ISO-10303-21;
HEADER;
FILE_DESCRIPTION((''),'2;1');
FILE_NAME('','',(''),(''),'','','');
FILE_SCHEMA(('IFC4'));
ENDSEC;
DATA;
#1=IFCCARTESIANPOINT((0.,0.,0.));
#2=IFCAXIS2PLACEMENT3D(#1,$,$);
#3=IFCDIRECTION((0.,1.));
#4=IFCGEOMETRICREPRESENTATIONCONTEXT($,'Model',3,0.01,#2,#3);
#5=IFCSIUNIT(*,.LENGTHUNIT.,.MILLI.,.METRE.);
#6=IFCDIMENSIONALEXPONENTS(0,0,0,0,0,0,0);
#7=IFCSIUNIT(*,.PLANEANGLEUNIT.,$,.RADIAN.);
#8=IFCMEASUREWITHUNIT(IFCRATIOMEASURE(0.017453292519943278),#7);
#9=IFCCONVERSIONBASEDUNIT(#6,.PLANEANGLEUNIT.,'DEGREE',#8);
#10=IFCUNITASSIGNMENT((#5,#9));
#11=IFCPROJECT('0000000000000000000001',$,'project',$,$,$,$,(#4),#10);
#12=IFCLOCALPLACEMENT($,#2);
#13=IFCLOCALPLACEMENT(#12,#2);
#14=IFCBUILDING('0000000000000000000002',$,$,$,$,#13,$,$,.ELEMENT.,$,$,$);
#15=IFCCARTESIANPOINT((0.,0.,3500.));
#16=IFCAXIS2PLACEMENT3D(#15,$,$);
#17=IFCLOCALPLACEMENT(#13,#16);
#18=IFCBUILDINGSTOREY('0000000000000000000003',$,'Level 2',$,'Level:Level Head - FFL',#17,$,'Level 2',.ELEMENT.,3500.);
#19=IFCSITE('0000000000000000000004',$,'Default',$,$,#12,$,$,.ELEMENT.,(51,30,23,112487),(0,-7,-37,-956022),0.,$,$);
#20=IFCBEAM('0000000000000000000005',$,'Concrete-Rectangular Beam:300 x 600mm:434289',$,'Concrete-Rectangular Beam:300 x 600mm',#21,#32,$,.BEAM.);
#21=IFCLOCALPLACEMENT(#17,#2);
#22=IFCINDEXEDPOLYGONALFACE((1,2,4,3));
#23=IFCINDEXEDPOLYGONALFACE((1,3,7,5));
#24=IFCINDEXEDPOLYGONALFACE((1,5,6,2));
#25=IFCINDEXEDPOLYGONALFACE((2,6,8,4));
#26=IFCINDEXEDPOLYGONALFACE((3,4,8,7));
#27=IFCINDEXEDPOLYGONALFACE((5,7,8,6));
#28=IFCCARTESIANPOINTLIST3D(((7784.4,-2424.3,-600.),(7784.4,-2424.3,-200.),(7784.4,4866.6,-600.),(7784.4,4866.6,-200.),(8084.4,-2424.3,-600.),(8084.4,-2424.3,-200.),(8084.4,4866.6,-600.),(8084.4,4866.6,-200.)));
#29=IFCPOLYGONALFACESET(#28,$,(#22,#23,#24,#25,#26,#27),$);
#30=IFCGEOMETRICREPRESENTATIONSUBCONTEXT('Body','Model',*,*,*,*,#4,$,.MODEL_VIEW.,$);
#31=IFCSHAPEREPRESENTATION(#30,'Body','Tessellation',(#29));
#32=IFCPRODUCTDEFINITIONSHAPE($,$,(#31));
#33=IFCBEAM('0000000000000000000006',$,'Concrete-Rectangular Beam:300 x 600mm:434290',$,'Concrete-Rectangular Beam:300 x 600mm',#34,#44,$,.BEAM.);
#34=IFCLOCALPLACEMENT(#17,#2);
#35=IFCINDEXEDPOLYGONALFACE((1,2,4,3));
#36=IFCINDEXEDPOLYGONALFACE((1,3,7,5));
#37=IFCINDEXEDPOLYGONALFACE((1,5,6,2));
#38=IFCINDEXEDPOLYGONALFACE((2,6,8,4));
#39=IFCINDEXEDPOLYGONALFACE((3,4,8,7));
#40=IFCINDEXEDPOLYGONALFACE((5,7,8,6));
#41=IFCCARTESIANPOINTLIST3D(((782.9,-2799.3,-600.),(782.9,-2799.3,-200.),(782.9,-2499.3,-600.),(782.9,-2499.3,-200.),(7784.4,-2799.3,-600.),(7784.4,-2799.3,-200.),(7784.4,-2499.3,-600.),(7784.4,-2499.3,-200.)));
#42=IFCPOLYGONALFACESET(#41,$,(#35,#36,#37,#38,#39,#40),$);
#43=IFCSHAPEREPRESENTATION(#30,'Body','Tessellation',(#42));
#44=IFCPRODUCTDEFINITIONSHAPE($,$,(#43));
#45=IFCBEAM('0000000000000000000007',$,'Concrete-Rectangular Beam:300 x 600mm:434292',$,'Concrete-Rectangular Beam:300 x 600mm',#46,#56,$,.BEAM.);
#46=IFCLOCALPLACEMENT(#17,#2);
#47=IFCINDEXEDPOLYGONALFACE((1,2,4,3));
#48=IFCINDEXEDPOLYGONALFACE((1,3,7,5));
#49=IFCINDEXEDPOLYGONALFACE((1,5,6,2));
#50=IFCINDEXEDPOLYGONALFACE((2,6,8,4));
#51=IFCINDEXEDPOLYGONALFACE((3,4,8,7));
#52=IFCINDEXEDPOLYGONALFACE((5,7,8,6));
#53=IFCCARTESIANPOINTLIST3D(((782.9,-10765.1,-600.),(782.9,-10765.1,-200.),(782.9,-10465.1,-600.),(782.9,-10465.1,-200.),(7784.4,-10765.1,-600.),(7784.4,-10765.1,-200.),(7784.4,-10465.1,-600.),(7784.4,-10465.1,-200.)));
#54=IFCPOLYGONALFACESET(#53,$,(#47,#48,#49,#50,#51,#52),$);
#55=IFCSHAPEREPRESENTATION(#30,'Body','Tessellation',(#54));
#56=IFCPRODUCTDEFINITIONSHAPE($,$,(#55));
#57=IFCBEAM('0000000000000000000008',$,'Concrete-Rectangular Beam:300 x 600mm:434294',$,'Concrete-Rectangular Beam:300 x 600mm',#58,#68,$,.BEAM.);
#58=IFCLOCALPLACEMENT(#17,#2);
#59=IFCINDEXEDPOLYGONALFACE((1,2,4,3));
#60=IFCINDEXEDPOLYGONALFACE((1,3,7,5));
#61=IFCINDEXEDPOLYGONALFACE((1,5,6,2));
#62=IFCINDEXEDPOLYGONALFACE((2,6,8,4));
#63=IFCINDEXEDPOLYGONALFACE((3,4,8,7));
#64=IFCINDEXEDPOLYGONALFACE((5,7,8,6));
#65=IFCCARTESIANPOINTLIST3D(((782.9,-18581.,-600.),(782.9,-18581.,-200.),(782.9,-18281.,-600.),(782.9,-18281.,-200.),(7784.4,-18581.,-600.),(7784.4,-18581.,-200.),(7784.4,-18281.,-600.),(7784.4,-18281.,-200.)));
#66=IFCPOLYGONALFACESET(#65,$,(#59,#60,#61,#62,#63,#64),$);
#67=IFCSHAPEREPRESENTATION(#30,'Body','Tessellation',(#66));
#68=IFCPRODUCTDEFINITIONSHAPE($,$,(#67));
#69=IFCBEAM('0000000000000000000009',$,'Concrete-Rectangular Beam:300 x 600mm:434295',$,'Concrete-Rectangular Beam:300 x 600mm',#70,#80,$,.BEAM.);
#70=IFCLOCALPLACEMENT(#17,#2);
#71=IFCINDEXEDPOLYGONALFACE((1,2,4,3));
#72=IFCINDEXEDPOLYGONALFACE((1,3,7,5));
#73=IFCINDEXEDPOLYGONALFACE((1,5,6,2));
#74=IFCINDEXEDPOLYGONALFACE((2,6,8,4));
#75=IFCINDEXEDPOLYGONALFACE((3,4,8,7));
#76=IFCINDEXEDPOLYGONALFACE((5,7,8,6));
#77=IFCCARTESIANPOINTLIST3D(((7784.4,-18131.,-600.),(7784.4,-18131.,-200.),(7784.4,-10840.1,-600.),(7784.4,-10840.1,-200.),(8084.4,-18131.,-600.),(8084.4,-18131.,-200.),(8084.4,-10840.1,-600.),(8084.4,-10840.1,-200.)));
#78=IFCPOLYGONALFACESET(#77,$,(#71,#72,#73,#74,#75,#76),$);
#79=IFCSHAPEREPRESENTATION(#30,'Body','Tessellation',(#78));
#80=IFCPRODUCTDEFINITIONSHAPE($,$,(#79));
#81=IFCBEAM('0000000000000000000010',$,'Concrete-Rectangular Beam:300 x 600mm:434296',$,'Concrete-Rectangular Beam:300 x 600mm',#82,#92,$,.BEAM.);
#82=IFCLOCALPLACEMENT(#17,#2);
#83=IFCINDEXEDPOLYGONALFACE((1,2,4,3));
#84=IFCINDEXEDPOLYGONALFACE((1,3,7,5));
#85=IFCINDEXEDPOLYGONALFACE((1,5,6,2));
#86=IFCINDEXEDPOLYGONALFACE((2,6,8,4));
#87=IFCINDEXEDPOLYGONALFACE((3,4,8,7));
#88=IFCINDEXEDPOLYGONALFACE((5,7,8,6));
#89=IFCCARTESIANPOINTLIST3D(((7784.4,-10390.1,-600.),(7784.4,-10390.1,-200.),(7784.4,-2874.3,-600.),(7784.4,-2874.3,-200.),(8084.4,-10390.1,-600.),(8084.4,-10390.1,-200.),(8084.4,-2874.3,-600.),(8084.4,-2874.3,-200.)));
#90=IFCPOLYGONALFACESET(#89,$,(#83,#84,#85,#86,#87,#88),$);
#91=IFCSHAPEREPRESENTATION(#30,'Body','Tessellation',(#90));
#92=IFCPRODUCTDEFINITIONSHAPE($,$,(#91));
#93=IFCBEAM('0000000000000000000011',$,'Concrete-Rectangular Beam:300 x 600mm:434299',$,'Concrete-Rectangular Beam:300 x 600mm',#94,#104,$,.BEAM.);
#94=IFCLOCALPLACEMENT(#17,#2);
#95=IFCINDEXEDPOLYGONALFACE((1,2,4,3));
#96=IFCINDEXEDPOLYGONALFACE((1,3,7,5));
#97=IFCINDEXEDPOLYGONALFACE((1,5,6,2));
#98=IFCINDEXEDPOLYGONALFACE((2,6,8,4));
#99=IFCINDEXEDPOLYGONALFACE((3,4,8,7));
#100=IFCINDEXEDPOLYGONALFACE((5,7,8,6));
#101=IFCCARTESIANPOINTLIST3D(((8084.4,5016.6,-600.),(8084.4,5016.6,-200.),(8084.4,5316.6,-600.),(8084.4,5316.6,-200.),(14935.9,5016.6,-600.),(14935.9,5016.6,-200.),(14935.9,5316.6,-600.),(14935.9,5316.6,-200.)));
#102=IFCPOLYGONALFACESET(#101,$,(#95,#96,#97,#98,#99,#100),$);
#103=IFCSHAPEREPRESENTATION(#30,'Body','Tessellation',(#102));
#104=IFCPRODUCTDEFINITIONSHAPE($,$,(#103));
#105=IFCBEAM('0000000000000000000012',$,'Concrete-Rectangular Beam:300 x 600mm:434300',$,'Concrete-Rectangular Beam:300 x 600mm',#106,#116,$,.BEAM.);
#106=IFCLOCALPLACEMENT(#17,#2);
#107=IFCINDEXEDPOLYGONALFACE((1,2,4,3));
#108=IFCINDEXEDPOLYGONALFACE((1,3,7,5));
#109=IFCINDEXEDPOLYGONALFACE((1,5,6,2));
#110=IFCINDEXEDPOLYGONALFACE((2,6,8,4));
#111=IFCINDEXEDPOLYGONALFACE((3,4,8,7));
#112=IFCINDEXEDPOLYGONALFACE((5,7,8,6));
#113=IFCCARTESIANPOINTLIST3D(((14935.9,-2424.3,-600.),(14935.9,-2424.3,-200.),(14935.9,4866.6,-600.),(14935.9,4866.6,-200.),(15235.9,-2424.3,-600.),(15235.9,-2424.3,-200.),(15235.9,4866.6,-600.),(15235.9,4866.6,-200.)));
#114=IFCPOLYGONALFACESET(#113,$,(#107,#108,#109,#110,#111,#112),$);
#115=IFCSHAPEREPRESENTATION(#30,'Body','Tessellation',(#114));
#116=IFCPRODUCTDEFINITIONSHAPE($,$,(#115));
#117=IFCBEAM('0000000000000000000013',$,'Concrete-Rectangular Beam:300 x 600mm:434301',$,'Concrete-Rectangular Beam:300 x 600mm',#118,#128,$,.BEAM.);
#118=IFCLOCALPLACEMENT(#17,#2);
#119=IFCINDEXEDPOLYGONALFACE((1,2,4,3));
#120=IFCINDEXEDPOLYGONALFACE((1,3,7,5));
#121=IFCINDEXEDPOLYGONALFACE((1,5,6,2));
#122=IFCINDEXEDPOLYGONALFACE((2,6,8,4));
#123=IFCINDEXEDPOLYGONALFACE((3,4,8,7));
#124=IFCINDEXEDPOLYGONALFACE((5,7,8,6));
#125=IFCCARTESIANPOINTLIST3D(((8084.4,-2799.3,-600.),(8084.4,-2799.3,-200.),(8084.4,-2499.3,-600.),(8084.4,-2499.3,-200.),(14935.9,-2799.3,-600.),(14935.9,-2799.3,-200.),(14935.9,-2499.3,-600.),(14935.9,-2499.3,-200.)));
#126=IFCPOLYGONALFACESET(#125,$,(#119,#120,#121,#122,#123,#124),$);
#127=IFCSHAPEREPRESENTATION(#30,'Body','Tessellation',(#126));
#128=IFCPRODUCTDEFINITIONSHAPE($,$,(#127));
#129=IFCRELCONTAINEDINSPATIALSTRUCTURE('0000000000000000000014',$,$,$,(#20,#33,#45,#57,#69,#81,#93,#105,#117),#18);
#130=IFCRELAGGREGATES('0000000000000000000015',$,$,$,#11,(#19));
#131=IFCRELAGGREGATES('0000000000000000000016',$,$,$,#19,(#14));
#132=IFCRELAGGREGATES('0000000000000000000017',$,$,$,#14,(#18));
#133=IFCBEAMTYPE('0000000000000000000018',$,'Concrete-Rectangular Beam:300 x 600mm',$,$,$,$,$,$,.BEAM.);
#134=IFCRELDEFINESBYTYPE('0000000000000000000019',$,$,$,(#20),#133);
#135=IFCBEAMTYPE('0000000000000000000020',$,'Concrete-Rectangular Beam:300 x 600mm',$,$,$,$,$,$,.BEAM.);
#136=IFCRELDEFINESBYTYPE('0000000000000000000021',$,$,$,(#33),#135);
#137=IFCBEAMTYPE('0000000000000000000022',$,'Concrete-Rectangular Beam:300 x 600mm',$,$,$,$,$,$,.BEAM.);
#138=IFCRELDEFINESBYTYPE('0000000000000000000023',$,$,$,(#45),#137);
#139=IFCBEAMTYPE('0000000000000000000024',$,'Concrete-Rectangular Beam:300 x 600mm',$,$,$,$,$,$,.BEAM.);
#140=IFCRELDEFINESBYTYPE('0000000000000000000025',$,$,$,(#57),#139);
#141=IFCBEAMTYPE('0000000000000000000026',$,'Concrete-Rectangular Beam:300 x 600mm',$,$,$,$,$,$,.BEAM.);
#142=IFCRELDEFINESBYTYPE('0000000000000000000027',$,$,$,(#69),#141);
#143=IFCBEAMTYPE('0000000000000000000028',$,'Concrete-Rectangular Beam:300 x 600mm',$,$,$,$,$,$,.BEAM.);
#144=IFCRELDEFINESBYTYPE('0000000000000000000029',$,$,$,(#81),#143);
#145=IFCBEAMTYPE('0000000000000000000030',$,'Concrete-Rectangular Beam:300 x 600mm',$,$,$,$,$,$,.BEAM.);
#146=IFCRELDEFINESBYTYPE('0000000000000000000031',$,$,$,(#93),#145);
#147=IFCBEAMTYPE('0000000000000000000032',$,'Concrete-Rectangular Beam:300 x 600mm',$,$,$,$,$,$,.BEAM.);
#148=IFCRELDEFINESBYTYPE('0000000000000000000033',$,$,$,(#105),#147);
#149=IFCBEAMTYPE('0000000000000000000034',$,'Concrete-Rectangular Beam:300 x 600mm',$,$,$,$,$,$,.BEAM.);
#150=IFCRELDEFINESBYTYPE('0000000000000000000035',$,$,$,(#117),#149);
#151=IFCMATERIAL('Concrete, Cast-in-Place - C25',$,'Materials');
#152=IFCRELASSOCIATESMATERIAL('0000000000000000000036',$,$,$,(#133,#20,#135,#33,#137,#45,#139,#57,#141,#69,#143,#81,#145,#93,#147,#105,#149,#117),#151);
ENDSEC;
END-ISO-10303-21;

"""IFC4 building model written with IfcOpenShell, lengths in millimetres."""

from ifc_helpers import new_model, entity, si_unit, converted_unit, direction, frame, origin, place, context, subcontext, project, spatial, indexed_curve, outline, extrude, source, transform, mapped, material, type_object, type_shapes, element, save


model = new_model("IFC4")

# Units and contexts
model_context = context("Model", 3, precision=0.01, world=origin(), true_north=direction((0.0, 1.0)))
body_context = subcontext(model_context, "Body", "Model", "MODEL_VIEW")
ifc_project = project(units=[si_unit("LENGTHUNIT", "METRE", prefix="MILLI"), converted_unit("PLANEANGLEUNIT", "DEGREE", entity("IfcRatioMeasure", 0.017453292519943278), si_unit("PLANEANGLEUNIT", "RADIAN"), dimensions=[0, 0, 0, 0, 0, 0, 0])], contexts=[model_context])

# Site, building, storey
site_placement = place(None, origin())
site = spatial("IfcSite", under=ifc_project, at=site_placement, Name="Default", CompositionType="ELEMENT", RefLatitude=(51, 30, 23, 112487), RefLongitude=(0, -7, -37, -956022), RefElevation=0.0)
building_placement = place(site_placement, origin())
building = spatial("IfcBuilding", under=site, at=building_placement, CompositionType="ELEMENT")
storey_placement = place(building_placement, frame((0.0, 0.0, 3500.0)))
storey = spatial("IfcBuildingStorey", under=building, at=storey_placement, Name="Level 2", ObjectType="Level:Level Head - FFL", LongName="Level 2", CompositionType="ELEMENT", Elevation=3500.0)

# Beams
ifc_material = material(Name="Concrete, Cast-in-Place - C25", Category="Materials")
beam_type_1 = type_object("IfcBeamType", Name="Concrete-Rectangular Beam:300 x 600mm", PredefinedType="BEAM", material=ifc_material)
shared_shape_1 = source(origin(), body_context, "Body", "SweptSolid", [
    extrude(outline(indexed_curve([(-150.0, -200.0), (150.0, -200.0), (150.0, 200.0), (-150.0, 200.0), (-150.0, -200.0)], self_intersect=False)), frame((7934.4, 4866.6, 3100.0), z_axis=(0.0, -1.0, 0.0), x_axis=(-1.0, 0.0, 0.0)), (0.0, 0.0, 1.0), 7290.9),
])
type_shapes(beam_type_1, [shared_shape_1])
beam_1_placement = place(storey_placement, frame((0.0, 0.0, -3500.0)))
element("IfcBeam", 1, at=beam_1_placement, inside=storey, type_object=beam_type_1, material=ifc_material, Name="Concrete-Rectangular Beam:300 x 600mm:434289", ObjectType="Concrete-Rectangular Beam:300 x 600mm", PredefinedType="BEAM", context=body_context, shape_type="MappedRepresentation", body=[
    mapped(shared_shape_1, transform((0.0, 0.0, 0.0), scale=1.0)),
])
beam_type_2 = type_object("IfcBeamType", Name="Concrete-Rectangular Beam:300 x 600mm", PredefinedType="BEAM", material=ifc_material)
shared_shape_2 = source(origin(), body_context, "Body", "SweptSolid", [
    extrude(outline(indexed_curve([(-200.0, -150.0), (200.0, -150.0), (200.0, 150.0), (-200.0, 150.0), (-200.0, -150.0)], self_intersect=False)), frame((7784.4, -2649.3, 3100.0), z_axis=(-1.0, 0.0, 0.0), x_axis=(0.0, 0.0, -1.0)), (0.0, 0.0, 1.0), 7001.5),
])
type_shapes(beam_type_2, [shared_shape_2])
beam_2_placement = place(storey_placement, frame((0.0, 0.0, -3500.0)))
element("IfcBeam", 2, at=beam_2_placement, inside=storey, type_object=beam_type_2, material=ifc_material, Name="Concrete-Rectangular Beam:300 x 600mm:434290", ObjectType="Concrete-Rectangular Beam:300 x 600mm", PredefinedType="BEAM", context=body_context, shape_type="MappedRepresentation", body=[
    mapped(shared_shape_2, transform((0.0, 0.0, 0.0), scale=1.0)),
])
beam_type_3 = type_object("IfcBeamType", Name="Concrete-Rectangular Beam:300 x 600mm", PredefinedType="BEAM", material=ifc_material)
shared_shape_3 = source(origin(), body_context, "Body", "SweptSolid", [
    extrude(outline(indexed_curve([(-200.0, -150.0), (200.0, -150.0), (200.0, 150.0), (-200.0, 150.0), (-200.0, -150.0)], self_intersect=False)), frame((7784.4, -10615.1, 3100.0), z_axis=(-1.0, 0.0, 0.0), x_axis=(0.0, 0.0, -1.0)), (0.0, 0.0, 1.0), 7001.5),
])
type_shapes(beam_type_3, [shared_shape_3])
beam_3_placement = place(storey_placement, frame((0.0, 0.0, -3500.0)))
element("IfcBeam", 3, at=beam_3_placement, inside=storey, type_object=beam_type_3, material=ifc_material, Name="Concrete-Rectangular Beam:300 x 600mm:434292", ObjectType="Concrete-Rectangular Beam:300 x 600mm", PredefinedType="BEAM", context=body_context, shape_type="MappedRepresentation", body=[
    mapped(shared_shape_3, transform((0.0, 0.0, 0.0), scale=1.0)),
])
beam_type_4 = type_object("IfcBeamType", Name="Concrete-Rectangular Beam:300 x 600mm", PredefinedType="BEAM", material=ifc_material)
shared_shape_4 = source(origin(), body_context, "Body", "SweptSolid", [
    extrude(outline(indexed_curve([(-200.0, -150.0), (200.0, -150.0), (200.0, 150.0), (-200.0, 150.0), (-200.0, -150.0)], self_intersect=False)), frame((7784.4, -18431.0, 3100.0), z_axis=(-1.0, 0.0, 0.0), x_axis=(0.0, 0.0, -1.0)), (0.0, 0.0, 1.0), 7001.5),
])
type_shapes(beam_type_4, [shared_shape_4])
beam_4_placement = place(storey_placement, frame((0.0, 0.0, -3500.0)))
element("IfcBeam", 4, at=beam_4_placement, inside=storey, type_object=beam_type_4, material=ifc_material, Name="Concrete-Rectangular Beam:300 x 600mm:434294", ObjectType="Concrete-Rectangular Beam:300 x 600mm", PredefinedType="BEAM", context=body_context, shape_type="MappedRepresentation", body=[
    mapped(shared_shape_4, transform((0.0, 0.0, 0.0), scale=1.0)),
])
beam_type_5 = type_object("IfcBeamType", Name="Concrete-Rectangular Beam:300 x 600mm", PredefinedType="BEAM", material=ifc_material)
shared_shape_5 = source(origin(), body_context, "Body", "SweptSolid", [
    extrude(outline(indexed_curve([(-150.0, -200.0), (150.0, -200.0), (150.0, 200.0), (-150.0, 200.0), (-150.0, -200.0)], self_intersect=False)), frame((7934.4, -18131.0, 3100.0), z_axis=(0.0, 1.0, 0.0), x_axis=(-1.0, 0.0, 0.0)), (0.0, 0.0, 1.0), 7290.9),
])
type_shapes(beam_type_5, [shared_shape_5])
beam_5_placement = place(storey_placement, frame((0.0, 0.0, -3500.0)))
element("IfcBeam", 5, at=beam_5_placement, inside=storey, type_object=beam_type_5, material=ifc_material, Name="Concrete-Rectangular Beam:300 x 600mm:434295", ObjectType="Concrete-Rectangular Beam:300 x 600mm", PredefinedType="BEAM", context=body_context, shape_type="MappedRepresentation", body=[
    mapped(shared_shape_5, transform((0.0, 0.0, 0.0), scale=1.0)),
])
beam_type_6 = type_object("IfcBeamType", Name="Concrete-Rectangular Beam:300 x 600mm", PredefinedType="BEAM", material=ifc_material)
shared_shape_6 = source(origin(), body_context, "Body", "SweptSolid", [
    extrude(outline(indexed_curve([(-150.0, -200.0), (150.0, -200.0), (150.0, 200.0), (-150.0, 200.0), (-150.0, -200.0)], self_intersect=False)), frame((7934.4, -10390.1, 3100.0), z_axis=(0.0, 1.0, 0.0), x_axis=(-1.0, 0.0, 0.0)), (0.0, 0.0, 1.0), 7515.9),
])
type_shapes(beam_type_6, [shared_shape_6])
beam_6_placement = place(storey_placement, frame((0.0, 0.0, -3500.0)))
element("IfcBeam", 6, at=beam_6_placement, inside=storey, type_object=beam_type_6, material=ifc_material, Name="Concrete-Rectangular Beam:300 x 600mm:434296", ObjectType="Concrete-Rectangular Beam:300 x 600mm", PredefinedType="BEAM", context=body_context, shape_type="MappedRepresentation", body=[
    mapped(shared_shape_6, transform((0.0, 0.0, 0.0), scale=1.0)),
])
beam_type_7 = type_object("IfcBeamType", Name="Concrete-Rectangular Beam:300 x 600mm", PredefinedType="BEAM", material=ifc_material)
shared_shape_7 = source(origin(), body_context, "Body", "SweptSolid", [
    extrude(outline(indexed_curve([(-200.0, -150.0), (200.0, -150.0), (200.0, 150.0), (-200.0, 150.0), (-200.0, -150.0)], self_intersect=False)), frame((8084.4, 5166.6, 3100.0), z_axis=(1.0, 0.0, 0.0), x_axis=(0.0, 0.0, -1.0)), (0.0, 0.0, 1.0), 6851.5),
])
type_shapes(beam_type_7, [shared_shape_7])
beam_7_placement = place(storey_placement, frame((0.0, 0.0, -3500.0)))
element("IfcBeam", 7, at=beam_7_placement, inside=storey, type_object=beam_type_7, material=ifc_material, Name="Concrete-Rectangular Beam:300 x 600mm:434299", ObjectType="Concrete-Rectangular Beam:300 x 600mm", PredefinedType="BEAM", context=body_context, shape_type="MappedRepresentation", body=[
    mapped(shared_shape_7, transform((0.0, 0.0, 0.0), scale=1.0)),
])
beam_type_8 = type_object("IfcBeamType", Name="Concrete-Rectangular Beam:300 x 600mm", PredefinedType="BEAM", material=ifc_material)
shared_shape_8 = source(origin(), body_context, "Body", "SweptSolid", [
    extrude(outline(indexed_curve([(-150.0, -200.0), (150.0, -200.0), (150.0, 200.0), (-150.0, 200.0), (-150.0, -200.0)], self_intersect=False)), frame((15085.9, 4866.6, 3100.0), z_axis=(0.0, -1.0, 0.0), x_axis=(-1.0, 0.0, 0.0)), (0.0, 0.0, 1.0), 7290.9),
])
type_shapes(beam_type_8, [shared_shape_8])
beam_8_placement = place(storey_placement, frame((0.0, 0.0, -3500.0)))
element("IfcBeam", 8, at=beam_8_placement, inside=storey, type_object=beam_type_8, material=ifc_material, Name="Concrete-Rectangular Beam:300 x 600mm:434300", ObjectType="Concrete-Rectangular Beam:300 x 600mm", PredefinedType="BEAM", context=body_context, shape_type="MappedRepresentation", body=[
    mapped(shared_shape_8, transform((0.0, 0.0, 0.0), scale=1.0)),
])
beam_type_9 = type_object("IfcBeamType", Name="Concrete-Rectangular Beam:300 x 600mm", PredefinedType="BEAM", material=ifc_material)
shared_shape_9 = source(origin(), body_context, "Body", "SweptSolid", [
    extrude(outline(indexed_curve([(-200.0, -150.0), (200.0, -150.0), (200.0, 150.0), (-200.0, 150.0), (-200.0, -150.0)], self_intersect=False)), frame((14935.9, -2649.3, 3100.0), z_axis=(-1.0, 0.0, 0.0), x_axis=(0.0, 0.0, -1.0)), (0.0, 0.0, 1.0), 6851.5),
])
type_shapes(beam_type_9, [shared_shape_9])
beam_9_placement = place(storey_placement, frame((0.0, 0.0, -3500.0)))
element("IfcBeam", 9, at=beam_9_placement, inside=storey, type_object=beam_type_9, material=ifc_material, Name="Concrete-Rectangular Beam:300 x 600mm:434301", ObjectType="Concrete-Rectangular Beam:300 x 600mm", PredefinedType="BEAM", context=body_context, shape_type="MappedRepresentation", body=[
    mapped(shared_shape_9, transform((0.0, 0.0, 0.0), scale=1.0)),
])

save(model, "model.ifc")
